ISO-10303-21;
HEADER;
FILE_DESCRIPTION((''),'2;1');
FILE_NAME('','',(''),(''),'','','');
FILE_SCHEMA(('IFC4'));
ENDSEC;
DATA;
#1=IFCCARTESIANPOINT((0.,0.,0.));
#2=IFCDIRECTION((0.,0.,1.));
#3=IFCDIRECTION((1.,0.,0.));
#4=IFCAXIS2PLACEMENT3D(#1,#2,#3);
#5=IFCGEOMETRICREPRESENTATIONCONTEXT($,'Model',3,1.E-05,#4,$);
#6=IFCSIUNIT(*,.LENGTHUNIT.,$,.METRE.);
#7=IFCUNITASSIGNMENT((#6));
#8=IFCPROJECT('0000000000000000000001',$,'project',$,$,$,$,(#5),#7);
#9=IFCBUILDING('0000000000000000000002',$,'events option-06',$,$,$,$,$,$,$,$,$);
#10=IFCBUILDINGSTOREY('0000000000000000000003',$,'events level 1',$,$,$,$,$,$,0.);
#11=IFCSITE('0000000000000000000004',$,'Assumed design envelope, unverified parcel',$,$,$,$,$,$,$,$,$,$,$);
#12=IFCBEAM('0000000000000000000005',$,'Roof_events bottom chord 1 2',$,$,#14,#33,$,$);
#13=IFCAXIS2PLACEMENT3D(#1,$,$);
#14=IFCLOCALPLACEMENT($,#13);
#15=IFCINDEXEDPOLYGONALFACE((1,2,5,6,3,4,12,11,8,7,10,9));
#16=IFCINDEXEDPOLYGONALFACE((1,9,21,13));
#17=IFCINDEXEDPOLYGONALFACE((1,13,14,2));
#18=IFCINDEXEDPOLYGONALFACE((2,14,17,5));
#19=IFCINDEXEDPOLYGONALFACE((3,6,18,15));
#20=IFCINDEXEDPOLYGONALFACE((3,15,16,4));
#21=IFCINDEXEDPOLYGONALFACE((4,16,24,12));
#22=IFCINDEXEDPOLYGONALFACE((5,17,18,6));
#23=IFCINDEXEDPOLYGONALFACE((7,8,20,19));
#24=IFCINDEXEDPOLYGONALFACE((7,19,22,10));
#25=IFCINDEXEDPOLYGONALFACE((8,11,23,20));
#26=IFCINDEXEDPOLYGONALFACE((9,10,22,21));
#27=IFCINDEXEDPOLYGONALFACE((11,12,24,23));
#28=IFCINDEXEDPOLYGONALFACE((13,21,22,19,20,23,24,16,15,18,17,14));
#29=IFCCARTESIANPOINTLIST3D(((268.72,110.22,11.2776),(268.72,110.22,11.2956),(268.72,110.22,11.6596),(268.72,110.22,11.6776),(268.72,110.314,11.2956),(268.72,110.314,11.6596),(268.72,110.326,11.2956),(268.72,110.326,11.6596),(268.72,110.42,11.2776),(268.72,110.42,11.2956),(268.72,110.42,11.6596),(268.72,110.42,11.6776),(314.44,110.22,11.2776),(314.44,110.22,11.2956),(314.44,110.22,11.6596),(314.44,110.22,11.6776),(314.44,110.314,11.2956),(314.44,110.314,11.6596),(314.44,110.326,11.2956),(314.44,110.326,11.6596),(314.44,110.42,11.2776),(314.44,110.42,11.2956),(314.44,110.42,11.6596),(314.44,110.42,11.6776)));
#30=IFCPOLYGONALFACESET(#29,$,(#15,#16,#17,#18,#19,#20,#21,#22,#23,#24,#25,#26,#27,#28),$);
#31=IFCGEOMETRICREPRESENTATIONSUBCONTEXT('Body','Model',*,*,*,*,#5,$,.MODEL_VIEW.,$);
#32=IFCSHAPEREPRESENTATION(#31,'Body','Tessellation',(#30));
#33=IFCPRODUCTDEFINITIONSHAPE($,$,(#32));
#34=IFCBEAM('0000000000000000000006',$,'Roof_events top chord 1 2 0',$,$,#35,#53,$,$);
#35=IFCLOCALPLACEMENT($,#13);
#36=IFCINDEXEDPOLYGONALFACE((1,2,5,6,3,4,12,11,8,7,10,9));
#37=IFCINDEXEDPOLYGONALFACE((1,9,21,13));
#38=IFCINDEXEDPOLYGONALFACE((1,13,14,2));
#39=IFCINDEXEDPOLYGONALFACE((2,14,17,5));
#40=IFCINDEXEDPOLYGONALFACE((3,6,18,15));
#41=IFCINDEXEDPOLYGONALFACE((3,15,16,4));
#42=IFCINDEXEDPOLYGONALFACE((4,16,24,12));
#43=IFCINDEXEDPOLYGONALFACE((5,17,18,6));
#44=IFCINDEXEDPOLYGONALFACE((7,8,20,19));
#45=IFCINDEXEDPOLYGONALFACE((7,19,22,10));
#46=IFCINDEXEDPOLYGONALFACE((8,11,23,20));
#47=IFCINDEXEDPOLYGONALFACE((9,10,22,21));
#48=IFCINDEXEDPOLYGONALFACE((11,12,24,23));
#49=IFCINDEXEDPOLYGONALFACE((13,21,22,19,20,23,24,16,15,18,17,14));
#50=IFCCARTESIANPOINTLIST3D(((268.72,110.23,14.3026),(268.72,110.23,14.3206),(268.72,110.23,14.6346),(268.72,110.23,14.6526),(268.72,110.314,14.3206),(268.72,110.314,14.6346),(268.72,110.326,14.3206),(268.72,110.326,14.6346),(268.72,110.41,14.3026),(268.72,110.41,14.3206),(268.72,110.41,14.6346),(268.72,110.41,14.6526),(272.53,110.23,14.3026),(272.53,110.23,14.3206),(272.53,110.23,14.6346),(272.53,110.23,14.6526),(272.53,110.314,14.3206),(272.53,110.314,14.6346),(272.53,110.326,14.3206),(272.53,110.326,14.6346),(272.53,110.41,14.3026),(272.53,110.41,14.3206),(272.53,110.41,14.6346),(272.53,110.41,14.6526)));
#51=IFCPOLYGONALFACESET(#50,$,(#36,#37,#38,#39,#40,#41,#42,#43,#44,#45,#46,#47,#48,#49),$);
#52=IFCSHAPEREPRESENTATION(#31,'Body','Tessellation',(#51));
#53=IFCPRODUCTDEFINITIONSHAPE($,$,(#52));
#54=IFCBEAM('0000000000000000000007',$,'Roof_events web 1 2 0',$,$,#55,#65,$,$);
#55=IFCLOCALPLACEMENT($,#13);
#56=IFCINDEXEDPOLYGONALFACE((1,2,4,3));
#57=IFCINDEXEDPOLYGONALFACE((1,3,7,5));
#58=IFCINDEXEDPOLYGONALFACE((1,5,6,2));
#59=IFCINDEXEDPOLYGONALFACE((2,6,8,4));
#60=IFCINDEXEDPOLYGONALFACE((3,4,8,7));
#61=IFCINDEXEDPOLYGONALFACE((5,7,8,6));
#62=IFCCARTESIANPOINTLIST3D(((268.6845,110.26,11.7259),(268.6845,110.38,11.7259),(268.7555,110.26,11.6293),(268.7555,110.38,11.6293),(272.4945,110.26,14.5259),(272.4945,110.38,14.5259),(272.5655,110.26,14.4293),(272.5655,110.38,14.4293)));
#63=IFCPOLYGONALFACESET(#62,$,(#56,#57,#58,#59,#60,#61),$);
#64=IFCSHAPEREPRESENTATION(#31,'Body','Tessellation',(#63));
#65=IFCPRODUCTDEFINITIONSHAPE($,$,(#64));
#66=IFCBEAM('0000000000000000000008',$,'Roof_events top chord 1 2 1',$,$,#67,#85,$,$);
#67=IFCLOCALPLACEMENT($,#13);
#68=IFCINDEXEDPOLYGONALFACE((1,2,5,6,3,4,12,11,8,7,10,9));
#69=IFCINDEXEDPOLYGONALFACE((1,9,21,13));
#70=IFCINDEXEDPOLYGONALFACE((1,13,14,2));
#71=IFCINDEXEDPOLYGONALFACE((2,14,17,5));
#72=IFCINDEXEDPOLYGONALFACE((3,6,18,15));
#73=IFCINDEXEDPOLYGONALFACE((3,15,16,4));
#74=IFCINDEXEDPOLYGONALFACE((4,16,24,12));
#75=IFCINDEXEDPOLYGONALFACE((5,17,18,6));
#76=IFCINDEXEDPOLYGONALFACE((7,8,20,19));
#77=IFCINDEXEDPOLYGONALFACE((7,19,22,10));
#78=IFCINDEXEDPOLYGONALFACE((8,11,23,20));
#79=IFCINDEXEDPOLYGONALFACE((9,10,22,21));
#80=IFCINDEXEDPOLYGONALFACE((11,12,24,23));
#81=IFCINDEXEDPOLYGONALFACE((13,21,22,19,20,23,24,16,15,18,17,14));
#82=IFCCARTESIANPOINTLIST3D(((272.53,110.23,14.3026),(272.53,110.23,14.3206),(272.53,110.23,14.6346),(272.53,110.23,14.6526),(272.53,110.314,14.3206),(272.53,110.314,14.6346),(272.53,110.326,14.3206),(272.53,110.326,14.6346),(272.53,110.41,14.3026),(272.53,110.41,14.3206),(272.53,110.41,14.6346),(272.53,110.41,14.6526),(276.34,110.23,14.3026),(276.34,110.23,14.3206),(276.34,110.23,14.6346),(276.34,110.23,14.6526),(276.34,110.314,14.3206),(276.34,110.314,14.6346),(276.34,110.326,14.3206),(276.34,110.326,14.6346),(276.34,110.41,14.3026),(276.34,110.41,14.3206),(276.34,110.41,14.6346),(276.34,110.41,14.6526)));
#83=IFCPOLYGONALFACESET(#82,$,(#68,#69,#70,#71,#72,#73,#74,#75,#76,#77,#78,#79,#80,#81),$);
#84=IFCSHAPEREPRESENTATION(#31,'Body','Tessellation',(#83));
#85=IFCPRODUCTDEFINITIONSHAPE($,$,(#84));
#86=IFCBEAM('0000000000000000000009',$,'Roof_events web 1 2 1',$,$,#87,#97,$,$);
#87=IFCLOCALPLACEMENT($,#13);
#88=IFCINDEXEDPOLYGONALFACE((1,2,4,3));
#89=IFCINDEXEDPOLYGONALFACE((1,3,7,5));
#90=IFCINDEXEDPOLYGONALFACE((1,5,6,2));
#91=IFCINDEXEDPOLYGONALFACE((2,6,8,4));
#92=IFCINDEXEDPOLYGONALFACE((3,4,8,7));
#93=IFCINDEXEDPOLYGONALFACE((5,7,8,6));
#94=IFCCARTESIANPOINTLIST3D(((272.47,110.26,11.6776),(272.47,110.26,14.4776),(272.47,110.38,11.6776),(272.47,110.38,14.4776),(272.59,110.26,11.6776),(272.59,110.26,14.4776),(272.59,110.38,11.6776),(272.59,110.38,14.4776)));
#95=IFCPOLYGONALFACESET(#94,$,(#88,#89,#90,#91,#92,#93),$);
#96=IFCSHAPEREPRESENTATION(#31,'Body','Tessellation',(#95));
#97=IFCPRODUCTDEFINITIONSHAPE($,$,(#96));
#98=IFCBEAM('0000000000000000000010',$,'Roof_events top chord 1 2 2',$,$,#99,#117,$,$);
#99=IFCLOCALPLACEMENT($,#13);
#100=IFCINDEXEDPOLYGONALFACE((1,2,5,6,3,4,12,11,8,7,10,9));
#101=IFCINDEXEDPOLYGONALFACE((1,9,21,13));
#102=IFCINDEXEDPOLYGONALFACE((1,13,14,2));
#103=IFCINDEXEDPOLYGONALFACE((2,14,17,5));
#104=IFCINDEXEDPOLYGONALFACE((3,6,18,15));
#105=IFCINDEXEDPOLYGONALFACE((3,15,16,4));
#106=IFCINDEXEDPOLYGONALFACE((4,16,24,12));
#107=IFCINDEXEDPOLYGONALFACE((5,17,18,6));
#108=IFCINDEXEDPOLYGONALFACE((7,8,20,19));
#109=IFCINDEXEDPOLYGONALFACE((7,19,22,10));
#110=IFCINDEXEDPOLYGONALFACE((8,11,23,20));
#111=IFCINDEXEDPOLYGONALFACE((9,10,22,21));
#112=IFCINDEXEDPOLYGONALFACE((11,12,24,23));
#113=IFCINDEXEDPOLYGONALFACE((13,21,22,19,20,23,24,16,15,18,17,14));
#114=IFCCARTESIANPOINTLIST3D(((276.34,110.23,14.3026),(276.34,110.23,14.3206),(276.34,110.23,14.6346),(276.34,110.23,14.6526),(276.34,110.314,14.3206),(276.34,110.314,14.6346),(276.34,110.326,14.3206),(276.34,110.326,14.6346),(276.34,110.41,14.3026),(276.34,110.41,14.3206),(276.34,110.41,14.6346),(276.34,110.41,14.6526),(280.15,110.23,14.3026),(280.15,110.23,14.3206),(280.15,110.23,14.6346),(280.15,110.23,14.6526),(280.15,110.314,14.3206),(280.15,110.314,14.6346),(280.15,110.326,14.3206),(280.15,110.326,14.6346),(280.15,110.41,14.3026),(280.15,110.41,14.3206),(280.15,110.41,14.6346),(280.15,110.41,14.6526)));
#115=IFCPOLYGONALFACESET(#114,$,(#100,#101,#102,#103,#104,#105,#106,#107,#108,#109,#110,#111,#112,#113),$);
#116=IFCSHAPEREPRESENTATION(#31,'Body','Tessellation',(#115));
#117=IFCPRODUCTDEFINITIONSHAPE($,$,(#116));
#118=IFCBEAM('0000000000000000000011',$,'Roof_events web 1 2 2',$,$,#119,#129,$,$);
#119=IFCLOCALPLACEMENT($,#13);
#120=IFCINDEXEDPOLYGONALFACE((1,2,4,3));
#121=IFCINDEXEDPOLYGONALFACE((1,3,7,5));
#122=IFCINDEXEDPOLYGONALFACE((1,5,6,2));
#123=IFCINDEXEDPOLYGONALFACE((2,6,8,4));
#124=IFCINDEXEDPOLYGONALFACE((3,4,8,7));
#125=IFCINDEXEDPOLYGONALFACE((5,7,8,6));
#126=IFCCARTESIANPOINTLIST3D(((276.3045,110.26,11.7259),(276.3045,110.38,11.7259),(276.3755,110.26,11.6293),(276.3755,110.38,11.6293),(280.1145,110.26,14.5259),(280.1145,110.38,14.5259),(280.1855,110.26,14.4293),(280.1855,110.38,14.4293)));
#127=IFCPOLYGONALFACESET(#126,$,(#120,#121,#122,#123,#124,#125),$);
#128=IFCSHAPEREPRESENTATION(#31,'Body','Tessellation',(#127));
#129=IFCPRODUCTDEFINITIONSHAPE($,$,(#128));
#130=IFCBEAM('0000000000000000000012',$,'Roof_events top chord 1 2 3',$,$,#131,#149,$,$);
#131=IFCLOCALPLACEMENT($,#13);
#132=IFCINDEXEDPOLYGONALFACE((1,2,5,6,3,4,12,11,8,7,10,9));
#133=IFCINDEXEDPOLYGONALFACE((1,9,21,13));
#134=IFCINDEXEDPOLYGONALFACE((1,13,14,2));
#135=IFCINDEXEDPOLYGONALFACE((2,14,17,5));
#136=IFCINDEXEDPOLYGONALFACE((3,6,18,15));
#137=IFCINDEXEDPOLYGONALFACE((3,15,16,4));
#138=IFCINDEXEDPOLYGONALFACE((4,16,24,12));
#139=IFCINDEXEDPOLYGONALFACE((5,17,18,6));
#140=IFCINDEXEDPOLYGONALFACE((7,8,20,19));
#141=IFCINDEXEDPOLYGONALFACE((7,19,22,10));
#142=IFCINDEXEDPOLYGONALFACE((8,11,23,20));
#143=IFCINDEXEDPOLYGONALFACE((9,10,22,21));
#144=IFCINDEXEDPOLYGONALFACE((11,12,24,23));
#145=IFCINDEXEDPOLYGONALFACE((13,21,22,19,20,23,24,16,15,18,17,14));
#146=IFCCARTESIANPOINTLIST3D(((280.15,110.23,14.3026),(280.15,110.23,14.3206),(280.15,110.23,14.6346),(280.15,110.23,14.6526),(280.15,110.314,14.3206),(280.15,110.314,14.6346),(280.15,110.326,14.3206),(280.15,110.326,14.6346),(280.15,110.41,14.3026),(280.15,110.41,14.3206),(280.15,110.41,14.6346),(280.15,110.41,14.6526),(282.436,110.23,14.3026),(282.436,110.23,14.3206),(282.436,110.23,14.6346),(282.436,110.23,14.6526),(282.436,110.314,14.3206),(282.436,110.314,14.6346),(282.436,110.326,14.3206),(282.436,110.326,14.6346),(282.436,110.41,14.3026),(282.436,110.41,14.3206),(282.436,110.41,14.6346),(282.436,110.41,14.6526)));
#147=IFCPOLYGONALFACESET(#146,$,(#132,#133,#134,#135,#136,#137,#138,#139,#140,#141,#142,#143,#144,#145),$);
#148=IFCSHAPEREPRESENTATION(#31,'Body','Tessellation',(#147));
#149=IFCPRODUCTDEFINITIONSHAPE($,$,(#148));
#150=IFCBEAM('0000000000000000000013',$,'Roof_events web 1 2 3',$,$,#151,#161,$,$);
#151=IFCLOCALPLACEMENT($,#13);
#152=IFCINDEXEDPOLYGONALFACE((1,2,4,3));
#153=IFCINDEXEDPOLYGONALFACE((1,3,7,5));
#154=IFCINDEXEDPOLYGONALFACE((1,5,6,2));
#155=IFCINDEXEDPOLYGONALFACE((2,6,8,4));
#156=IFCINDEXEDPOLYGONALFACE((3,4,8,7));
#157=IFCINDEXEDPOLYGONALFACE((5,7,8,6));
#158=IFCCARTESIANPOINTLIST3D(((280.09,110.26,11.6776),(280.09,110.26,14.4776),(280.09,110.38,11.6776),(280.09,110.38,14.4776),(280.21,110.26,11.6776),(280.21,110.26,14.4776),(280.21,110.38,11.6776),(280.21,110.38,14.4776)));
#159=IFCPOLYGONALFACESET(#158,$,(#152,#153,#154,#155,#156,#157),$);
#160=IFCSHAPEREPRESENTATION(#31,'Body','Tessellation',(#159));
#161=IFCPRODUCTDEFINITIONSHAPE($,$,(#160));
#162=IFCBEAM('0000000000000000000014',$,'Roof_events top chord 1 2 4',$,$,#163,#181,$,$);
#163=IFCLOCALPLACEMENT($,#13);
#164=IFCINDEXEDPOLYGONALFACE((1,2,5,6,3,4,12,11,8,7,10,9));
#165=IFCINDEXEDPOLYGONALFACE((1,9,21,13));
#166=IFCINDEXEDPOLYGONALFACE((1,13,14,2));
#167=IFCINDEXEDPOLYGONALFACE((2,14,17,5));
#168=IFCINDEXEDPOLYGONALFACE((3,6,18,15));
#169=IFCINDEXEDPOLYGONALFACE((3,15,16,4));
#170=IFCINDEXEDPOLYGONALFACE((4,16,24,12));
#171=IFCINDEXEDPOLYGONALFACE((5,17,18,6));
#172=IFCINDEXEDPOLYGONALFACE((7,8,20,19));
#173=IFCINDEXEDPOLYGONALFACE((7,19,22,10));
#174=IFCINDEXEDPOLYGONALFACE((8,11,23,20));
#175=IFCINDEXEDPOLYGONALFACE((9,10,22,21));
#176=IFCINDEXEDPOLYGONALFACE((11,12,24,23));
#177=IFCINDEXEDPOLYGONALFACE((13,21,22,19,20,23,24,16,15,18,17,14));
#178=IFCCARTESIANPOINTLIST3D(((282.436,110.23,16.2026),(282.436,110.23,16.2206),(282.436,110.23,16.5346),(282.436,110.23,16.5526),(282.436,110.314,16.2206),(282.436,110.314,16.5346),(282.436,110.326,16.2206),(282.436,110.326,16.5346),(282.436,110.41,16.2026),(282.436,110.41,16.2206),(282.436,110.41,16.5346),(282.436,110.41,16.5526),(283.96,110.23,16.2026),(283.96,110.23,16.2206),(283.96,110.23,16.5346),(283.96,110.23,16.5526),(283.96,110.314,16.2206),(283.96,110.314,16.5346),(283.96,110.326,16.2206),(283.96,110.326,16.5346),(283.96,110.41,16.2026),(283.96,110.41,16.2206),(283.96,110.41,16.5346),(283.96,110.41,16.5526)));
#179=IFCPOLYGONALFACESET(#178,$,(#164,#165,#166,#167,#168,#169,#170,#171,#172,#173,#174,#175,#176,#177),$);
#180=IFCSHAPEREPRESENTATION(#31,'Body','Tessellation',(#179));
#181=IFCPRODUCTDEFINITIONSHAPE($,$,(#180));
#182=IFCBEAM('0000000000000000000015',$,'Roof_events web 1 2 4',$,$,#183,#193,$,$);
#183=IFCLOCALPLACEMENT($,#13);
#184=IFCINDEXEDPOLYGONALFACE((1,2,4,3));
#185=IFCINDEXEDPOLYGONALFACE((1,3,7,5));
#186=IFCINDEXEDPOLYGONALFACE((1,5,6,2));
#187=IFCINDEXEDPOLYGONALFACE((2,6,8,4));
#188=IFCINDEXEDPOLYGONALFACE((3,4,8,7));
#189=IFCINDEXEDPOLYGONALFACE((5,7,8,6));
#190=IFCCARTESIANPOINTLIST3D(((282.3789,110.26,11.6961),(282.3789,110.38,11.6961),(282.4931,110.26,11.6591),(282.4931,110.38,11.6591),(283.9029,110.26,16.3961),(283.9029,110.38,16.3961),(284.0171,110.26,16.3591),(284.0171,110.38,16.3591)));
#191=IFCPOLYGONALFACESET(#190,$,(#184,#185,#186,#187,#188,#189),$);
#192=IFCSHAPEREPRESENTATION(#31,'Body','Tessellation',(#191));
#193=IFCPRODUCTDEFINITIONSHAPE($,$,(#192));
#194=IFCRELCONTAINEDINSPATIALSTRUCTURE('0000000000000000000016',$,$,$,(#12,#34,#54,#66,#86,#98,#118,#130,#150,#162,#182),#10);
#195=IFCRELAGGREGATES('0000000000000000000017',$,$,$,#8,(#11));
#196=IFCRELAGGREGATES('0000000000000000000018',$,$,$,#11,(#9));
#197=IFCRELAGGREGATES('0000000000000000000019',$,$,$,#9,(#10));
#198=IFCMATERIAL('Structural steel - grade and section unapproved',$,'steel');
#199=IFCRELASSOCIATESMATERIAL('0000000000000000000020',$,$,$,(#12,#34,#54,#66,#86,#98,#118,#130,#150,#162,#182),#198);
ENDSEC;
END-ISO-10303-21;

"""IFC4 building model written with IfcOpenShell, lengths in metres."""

from ifc_helpers import new_model, si_unit, frame, origin_with_axes, place, context, subcontext, project, spatial, rectangle, i_section, extrude, material, element, save


model = new_model("IFC4")

# Units and contexts
model_context = context("Model", 3, precision=1e-05, world=origin_with_axes())
body_context = subcontext(model_context, "Body", "Model", "MODEL_VIEW")
ifc_project = project(units=[si_unit("LENGTHUNIT", "METRE")], contexts=[model_context])

# Site, building, storey
site = spatial("IfcSite", under=ifc_project, Name="Assumed design envelope, unverified parcel")
building = spatial("IfcBuilding", under=site, Name="events option-06")
storey = spatial("IfcBuildingStorey", under=building, Name="events level 1", Elevation=0.0)

# Shared definitions
ifc_material = material(Name="Structural steel - grade and section unapproved", Category="steel")

# Beams
beam_1_placement = place(None, frame((268.72, 110.32, 11.4776), z_axis=(1.0, 0.0, 0.0), x_axis=(0.0, 1.0, 0.0)))
element("IfcBeam", 1, at=beam_1_placement, inside=storey, material=ifc_material, Name="Roof_events bottom chord 1 2", context=body_context, shape_type="SweptSolid", body=[
    extrude(i_section(OverallWidth=0.2, OverallDepth=0.4, WebThickness=0.012, FlangeThickness=0.018, FilletRadius=0.0), origin_with_axes(), (0.0, 0.0, 1.0), 45.72),
])
beam_2_placement = place(None, frame((268.72, 110.32, 14.4776), z_axis=(1.0, 0.0, 0.0), x_axis=(0.0, 1.0, 0.0)))
element("IfcBeam", 2, at=beam_2_placement, inside=storey, material=ifc_material, Name="Roof_events top chord 1 2 0", context=body_context, shape_type="SweptSolid", body=[
    extrude(i_section(OverallWidth=0.18, OverallDepth=0.35, WebThickness=0.012, FlangeThickness=0.018, FilletRadius=0.0), origin_with_axes(), (0.0, 0.0, 1.0), 3.81),
])
beam_3_placement = place(None, frame((268.72, 110.32, 11.6776), z_axis=(0.805799, 0.0, 0.592189), x_axis=(0.0, 1.0, 0.0)))
element("IfcBeam", 3, at=beam_3_placement, inside=storey, material=ifc_material, Name="Roof_events web 1 2 0", context=body_context, shape_type="SweptSolid", body=[
    extrude(rectangle(XDim=0.12, YDim=0.12), origin_with_axes(), (0.0, 0.0, 1.0), 4.7282),
])
beam_4_placement = place(None, frame((272.53, 110.32, 14.4776), z_axis=(1.0, 0.0, 0.0), x_axis=(0.0, 1.0, 0.0)))
element("IfcBeam", 4, at=beam_4_placement, inside=storey, material=ifc_material, Name="Roof_events top chord 1 2 1", context=body_context, shape_type="SweptSolid", body=[
    extrude(i_section(OverallWidth=0.18, OverallDepth=0.35, WebThickness=0.012, FlangeThickness=0.018, FilletRadius=0.0), origin_with_axes(), (0.0, 0.0, 1.0), 3.81),
])
beam_5_placement = place(None, frame((272.53, 110.32, 11.6776), z_axis=(0.0, 0.0, 1.0), x_axis=(-1.0, 0.0, 0.0)))
element("IfcBeam", 5, at=beam_5_placement, inside=storey, material=ifc_material, Name="Roof_events web 1 2 1", context=body_context, shape_type="SweptSolid", body=[
    extrude(rectangle(XDim=0.12, YDim=0.12), origin_with_axes(), (0.0, 0.0, 1.0), 2.8),
])
beam_6_placement = place(None, frame((276.34, 110.32, 14.4776), z_axis=(1.0, 0.0, 0.0), x_axis=(0.0, 1.0, 0.0)))
element("IfcBeam", 6, at=beam_6_placement, inside=storey, material=ifc_material, Name="Roof_events top chord 1 2 2", context=body_context, shape_type="SweptSolid", body=[
    extrude(i_section(OverallWidth=0.18, OverallDepth=0.35, WebThickness=0.012, FlangeThickness=0.018, FilletRadius=0.0), origin_with_axes(), (0.0, 0.0, 1.0), 3.81),
])
beam_7_placement = place(None, frame((276.34, 110.32, 11.6776), z_axis=(0.805799, 0.0, 0.592189), x_axis=(0.0, 1.0, 0.0)))
element("IfcBeam", 7, at=beam_7_placement, inside=storey, material=ifc_material, Name="Roof_events web 1 2 2", context=body_context, shape_type="SweptSolid", body=[
    extrude(rectangle(XDim=0.12, YDim=0.12), origin_with_axes(), (0.0, 0.0, 1.0), 4.7282),
])
beam_8_placement = place(None, frame((280.15, 110.32, 14.4776), z_axis=(1.0, 0.0, 0.0), x_axis=(0.0, 1.0, 0.0)))
element("IfcBeam", 8, at=beam_8_placement, inside=storey, material=ifc_material, Name="Roof_events top chord 1 2 3", context=body_context, shape_type="SweptSolid", body=[
    extrude(i_section(OverallWidth=0.18, OverallDepth=0.35, WebThickness=0.012, FlangeThickness=0.018, FilletRadius=0.0), origin_with_axes(), (0.0, 0.0, 1.0), 2.286),
])
beam_9_placement = place(None, frame((280.15, 110.32, 11.6776), z_axis=(0.0, 0.0, 1.0), x_axis=(-1.0, 0.0, 0.0)))
element("IfcBeam", 9, at=beam_9_placement, inside=storey, material=ifc_material, Name="Roof_events web 1 2 3", context=body_context, shape_type="SweptSolid", body=[
    extrude(rectangle(XDim=0.12, YDim=0.12), origin_with_axes(), (0.0, 0.0, 1.0), 2.8),
])
beam_10_placement = place(None, frame((282.436, 110.32, 16.3776), z_axis=(1.0, 0.0, 0.0), x_axis=(0.0, 1.0, 0.0)))
element("IfcBeam", 10, at=beam_10_placement, inside=storey, material=ifc_material, Name="Roof_events top chord 1 2 4", context=body_context, shape_type="SweptSolid", body=[
    extrude(i_section(OverallWidth=0.18, OverallDepth=0.35, WebThickness=0.012, FlangeThickness=0.018, FilletRadius=0.0), origin_with_axes(), (0.0, 0.0, 1.0), 1.524),
])
beam_11_placement = place(None, frame((282.436, 110.32, 11.6776), z_axis=(0.308443, 0.0, 0.951243), x_axis=(0.0, 1.0, 0.0)))
element("IfcBeam", 11, at=beam_11_placement, inside=storey, material=ifc_material, Name="Roof_events web 1 2 4", context=body_context, shape_type="SweptSolid", body=[
    extrude(rectangle(XDim=0.12, YDim=0.12), origin_with_axes(), (0.0, 0.0, 1.0), 4.9409),
])

save(model, "model.ifc")
